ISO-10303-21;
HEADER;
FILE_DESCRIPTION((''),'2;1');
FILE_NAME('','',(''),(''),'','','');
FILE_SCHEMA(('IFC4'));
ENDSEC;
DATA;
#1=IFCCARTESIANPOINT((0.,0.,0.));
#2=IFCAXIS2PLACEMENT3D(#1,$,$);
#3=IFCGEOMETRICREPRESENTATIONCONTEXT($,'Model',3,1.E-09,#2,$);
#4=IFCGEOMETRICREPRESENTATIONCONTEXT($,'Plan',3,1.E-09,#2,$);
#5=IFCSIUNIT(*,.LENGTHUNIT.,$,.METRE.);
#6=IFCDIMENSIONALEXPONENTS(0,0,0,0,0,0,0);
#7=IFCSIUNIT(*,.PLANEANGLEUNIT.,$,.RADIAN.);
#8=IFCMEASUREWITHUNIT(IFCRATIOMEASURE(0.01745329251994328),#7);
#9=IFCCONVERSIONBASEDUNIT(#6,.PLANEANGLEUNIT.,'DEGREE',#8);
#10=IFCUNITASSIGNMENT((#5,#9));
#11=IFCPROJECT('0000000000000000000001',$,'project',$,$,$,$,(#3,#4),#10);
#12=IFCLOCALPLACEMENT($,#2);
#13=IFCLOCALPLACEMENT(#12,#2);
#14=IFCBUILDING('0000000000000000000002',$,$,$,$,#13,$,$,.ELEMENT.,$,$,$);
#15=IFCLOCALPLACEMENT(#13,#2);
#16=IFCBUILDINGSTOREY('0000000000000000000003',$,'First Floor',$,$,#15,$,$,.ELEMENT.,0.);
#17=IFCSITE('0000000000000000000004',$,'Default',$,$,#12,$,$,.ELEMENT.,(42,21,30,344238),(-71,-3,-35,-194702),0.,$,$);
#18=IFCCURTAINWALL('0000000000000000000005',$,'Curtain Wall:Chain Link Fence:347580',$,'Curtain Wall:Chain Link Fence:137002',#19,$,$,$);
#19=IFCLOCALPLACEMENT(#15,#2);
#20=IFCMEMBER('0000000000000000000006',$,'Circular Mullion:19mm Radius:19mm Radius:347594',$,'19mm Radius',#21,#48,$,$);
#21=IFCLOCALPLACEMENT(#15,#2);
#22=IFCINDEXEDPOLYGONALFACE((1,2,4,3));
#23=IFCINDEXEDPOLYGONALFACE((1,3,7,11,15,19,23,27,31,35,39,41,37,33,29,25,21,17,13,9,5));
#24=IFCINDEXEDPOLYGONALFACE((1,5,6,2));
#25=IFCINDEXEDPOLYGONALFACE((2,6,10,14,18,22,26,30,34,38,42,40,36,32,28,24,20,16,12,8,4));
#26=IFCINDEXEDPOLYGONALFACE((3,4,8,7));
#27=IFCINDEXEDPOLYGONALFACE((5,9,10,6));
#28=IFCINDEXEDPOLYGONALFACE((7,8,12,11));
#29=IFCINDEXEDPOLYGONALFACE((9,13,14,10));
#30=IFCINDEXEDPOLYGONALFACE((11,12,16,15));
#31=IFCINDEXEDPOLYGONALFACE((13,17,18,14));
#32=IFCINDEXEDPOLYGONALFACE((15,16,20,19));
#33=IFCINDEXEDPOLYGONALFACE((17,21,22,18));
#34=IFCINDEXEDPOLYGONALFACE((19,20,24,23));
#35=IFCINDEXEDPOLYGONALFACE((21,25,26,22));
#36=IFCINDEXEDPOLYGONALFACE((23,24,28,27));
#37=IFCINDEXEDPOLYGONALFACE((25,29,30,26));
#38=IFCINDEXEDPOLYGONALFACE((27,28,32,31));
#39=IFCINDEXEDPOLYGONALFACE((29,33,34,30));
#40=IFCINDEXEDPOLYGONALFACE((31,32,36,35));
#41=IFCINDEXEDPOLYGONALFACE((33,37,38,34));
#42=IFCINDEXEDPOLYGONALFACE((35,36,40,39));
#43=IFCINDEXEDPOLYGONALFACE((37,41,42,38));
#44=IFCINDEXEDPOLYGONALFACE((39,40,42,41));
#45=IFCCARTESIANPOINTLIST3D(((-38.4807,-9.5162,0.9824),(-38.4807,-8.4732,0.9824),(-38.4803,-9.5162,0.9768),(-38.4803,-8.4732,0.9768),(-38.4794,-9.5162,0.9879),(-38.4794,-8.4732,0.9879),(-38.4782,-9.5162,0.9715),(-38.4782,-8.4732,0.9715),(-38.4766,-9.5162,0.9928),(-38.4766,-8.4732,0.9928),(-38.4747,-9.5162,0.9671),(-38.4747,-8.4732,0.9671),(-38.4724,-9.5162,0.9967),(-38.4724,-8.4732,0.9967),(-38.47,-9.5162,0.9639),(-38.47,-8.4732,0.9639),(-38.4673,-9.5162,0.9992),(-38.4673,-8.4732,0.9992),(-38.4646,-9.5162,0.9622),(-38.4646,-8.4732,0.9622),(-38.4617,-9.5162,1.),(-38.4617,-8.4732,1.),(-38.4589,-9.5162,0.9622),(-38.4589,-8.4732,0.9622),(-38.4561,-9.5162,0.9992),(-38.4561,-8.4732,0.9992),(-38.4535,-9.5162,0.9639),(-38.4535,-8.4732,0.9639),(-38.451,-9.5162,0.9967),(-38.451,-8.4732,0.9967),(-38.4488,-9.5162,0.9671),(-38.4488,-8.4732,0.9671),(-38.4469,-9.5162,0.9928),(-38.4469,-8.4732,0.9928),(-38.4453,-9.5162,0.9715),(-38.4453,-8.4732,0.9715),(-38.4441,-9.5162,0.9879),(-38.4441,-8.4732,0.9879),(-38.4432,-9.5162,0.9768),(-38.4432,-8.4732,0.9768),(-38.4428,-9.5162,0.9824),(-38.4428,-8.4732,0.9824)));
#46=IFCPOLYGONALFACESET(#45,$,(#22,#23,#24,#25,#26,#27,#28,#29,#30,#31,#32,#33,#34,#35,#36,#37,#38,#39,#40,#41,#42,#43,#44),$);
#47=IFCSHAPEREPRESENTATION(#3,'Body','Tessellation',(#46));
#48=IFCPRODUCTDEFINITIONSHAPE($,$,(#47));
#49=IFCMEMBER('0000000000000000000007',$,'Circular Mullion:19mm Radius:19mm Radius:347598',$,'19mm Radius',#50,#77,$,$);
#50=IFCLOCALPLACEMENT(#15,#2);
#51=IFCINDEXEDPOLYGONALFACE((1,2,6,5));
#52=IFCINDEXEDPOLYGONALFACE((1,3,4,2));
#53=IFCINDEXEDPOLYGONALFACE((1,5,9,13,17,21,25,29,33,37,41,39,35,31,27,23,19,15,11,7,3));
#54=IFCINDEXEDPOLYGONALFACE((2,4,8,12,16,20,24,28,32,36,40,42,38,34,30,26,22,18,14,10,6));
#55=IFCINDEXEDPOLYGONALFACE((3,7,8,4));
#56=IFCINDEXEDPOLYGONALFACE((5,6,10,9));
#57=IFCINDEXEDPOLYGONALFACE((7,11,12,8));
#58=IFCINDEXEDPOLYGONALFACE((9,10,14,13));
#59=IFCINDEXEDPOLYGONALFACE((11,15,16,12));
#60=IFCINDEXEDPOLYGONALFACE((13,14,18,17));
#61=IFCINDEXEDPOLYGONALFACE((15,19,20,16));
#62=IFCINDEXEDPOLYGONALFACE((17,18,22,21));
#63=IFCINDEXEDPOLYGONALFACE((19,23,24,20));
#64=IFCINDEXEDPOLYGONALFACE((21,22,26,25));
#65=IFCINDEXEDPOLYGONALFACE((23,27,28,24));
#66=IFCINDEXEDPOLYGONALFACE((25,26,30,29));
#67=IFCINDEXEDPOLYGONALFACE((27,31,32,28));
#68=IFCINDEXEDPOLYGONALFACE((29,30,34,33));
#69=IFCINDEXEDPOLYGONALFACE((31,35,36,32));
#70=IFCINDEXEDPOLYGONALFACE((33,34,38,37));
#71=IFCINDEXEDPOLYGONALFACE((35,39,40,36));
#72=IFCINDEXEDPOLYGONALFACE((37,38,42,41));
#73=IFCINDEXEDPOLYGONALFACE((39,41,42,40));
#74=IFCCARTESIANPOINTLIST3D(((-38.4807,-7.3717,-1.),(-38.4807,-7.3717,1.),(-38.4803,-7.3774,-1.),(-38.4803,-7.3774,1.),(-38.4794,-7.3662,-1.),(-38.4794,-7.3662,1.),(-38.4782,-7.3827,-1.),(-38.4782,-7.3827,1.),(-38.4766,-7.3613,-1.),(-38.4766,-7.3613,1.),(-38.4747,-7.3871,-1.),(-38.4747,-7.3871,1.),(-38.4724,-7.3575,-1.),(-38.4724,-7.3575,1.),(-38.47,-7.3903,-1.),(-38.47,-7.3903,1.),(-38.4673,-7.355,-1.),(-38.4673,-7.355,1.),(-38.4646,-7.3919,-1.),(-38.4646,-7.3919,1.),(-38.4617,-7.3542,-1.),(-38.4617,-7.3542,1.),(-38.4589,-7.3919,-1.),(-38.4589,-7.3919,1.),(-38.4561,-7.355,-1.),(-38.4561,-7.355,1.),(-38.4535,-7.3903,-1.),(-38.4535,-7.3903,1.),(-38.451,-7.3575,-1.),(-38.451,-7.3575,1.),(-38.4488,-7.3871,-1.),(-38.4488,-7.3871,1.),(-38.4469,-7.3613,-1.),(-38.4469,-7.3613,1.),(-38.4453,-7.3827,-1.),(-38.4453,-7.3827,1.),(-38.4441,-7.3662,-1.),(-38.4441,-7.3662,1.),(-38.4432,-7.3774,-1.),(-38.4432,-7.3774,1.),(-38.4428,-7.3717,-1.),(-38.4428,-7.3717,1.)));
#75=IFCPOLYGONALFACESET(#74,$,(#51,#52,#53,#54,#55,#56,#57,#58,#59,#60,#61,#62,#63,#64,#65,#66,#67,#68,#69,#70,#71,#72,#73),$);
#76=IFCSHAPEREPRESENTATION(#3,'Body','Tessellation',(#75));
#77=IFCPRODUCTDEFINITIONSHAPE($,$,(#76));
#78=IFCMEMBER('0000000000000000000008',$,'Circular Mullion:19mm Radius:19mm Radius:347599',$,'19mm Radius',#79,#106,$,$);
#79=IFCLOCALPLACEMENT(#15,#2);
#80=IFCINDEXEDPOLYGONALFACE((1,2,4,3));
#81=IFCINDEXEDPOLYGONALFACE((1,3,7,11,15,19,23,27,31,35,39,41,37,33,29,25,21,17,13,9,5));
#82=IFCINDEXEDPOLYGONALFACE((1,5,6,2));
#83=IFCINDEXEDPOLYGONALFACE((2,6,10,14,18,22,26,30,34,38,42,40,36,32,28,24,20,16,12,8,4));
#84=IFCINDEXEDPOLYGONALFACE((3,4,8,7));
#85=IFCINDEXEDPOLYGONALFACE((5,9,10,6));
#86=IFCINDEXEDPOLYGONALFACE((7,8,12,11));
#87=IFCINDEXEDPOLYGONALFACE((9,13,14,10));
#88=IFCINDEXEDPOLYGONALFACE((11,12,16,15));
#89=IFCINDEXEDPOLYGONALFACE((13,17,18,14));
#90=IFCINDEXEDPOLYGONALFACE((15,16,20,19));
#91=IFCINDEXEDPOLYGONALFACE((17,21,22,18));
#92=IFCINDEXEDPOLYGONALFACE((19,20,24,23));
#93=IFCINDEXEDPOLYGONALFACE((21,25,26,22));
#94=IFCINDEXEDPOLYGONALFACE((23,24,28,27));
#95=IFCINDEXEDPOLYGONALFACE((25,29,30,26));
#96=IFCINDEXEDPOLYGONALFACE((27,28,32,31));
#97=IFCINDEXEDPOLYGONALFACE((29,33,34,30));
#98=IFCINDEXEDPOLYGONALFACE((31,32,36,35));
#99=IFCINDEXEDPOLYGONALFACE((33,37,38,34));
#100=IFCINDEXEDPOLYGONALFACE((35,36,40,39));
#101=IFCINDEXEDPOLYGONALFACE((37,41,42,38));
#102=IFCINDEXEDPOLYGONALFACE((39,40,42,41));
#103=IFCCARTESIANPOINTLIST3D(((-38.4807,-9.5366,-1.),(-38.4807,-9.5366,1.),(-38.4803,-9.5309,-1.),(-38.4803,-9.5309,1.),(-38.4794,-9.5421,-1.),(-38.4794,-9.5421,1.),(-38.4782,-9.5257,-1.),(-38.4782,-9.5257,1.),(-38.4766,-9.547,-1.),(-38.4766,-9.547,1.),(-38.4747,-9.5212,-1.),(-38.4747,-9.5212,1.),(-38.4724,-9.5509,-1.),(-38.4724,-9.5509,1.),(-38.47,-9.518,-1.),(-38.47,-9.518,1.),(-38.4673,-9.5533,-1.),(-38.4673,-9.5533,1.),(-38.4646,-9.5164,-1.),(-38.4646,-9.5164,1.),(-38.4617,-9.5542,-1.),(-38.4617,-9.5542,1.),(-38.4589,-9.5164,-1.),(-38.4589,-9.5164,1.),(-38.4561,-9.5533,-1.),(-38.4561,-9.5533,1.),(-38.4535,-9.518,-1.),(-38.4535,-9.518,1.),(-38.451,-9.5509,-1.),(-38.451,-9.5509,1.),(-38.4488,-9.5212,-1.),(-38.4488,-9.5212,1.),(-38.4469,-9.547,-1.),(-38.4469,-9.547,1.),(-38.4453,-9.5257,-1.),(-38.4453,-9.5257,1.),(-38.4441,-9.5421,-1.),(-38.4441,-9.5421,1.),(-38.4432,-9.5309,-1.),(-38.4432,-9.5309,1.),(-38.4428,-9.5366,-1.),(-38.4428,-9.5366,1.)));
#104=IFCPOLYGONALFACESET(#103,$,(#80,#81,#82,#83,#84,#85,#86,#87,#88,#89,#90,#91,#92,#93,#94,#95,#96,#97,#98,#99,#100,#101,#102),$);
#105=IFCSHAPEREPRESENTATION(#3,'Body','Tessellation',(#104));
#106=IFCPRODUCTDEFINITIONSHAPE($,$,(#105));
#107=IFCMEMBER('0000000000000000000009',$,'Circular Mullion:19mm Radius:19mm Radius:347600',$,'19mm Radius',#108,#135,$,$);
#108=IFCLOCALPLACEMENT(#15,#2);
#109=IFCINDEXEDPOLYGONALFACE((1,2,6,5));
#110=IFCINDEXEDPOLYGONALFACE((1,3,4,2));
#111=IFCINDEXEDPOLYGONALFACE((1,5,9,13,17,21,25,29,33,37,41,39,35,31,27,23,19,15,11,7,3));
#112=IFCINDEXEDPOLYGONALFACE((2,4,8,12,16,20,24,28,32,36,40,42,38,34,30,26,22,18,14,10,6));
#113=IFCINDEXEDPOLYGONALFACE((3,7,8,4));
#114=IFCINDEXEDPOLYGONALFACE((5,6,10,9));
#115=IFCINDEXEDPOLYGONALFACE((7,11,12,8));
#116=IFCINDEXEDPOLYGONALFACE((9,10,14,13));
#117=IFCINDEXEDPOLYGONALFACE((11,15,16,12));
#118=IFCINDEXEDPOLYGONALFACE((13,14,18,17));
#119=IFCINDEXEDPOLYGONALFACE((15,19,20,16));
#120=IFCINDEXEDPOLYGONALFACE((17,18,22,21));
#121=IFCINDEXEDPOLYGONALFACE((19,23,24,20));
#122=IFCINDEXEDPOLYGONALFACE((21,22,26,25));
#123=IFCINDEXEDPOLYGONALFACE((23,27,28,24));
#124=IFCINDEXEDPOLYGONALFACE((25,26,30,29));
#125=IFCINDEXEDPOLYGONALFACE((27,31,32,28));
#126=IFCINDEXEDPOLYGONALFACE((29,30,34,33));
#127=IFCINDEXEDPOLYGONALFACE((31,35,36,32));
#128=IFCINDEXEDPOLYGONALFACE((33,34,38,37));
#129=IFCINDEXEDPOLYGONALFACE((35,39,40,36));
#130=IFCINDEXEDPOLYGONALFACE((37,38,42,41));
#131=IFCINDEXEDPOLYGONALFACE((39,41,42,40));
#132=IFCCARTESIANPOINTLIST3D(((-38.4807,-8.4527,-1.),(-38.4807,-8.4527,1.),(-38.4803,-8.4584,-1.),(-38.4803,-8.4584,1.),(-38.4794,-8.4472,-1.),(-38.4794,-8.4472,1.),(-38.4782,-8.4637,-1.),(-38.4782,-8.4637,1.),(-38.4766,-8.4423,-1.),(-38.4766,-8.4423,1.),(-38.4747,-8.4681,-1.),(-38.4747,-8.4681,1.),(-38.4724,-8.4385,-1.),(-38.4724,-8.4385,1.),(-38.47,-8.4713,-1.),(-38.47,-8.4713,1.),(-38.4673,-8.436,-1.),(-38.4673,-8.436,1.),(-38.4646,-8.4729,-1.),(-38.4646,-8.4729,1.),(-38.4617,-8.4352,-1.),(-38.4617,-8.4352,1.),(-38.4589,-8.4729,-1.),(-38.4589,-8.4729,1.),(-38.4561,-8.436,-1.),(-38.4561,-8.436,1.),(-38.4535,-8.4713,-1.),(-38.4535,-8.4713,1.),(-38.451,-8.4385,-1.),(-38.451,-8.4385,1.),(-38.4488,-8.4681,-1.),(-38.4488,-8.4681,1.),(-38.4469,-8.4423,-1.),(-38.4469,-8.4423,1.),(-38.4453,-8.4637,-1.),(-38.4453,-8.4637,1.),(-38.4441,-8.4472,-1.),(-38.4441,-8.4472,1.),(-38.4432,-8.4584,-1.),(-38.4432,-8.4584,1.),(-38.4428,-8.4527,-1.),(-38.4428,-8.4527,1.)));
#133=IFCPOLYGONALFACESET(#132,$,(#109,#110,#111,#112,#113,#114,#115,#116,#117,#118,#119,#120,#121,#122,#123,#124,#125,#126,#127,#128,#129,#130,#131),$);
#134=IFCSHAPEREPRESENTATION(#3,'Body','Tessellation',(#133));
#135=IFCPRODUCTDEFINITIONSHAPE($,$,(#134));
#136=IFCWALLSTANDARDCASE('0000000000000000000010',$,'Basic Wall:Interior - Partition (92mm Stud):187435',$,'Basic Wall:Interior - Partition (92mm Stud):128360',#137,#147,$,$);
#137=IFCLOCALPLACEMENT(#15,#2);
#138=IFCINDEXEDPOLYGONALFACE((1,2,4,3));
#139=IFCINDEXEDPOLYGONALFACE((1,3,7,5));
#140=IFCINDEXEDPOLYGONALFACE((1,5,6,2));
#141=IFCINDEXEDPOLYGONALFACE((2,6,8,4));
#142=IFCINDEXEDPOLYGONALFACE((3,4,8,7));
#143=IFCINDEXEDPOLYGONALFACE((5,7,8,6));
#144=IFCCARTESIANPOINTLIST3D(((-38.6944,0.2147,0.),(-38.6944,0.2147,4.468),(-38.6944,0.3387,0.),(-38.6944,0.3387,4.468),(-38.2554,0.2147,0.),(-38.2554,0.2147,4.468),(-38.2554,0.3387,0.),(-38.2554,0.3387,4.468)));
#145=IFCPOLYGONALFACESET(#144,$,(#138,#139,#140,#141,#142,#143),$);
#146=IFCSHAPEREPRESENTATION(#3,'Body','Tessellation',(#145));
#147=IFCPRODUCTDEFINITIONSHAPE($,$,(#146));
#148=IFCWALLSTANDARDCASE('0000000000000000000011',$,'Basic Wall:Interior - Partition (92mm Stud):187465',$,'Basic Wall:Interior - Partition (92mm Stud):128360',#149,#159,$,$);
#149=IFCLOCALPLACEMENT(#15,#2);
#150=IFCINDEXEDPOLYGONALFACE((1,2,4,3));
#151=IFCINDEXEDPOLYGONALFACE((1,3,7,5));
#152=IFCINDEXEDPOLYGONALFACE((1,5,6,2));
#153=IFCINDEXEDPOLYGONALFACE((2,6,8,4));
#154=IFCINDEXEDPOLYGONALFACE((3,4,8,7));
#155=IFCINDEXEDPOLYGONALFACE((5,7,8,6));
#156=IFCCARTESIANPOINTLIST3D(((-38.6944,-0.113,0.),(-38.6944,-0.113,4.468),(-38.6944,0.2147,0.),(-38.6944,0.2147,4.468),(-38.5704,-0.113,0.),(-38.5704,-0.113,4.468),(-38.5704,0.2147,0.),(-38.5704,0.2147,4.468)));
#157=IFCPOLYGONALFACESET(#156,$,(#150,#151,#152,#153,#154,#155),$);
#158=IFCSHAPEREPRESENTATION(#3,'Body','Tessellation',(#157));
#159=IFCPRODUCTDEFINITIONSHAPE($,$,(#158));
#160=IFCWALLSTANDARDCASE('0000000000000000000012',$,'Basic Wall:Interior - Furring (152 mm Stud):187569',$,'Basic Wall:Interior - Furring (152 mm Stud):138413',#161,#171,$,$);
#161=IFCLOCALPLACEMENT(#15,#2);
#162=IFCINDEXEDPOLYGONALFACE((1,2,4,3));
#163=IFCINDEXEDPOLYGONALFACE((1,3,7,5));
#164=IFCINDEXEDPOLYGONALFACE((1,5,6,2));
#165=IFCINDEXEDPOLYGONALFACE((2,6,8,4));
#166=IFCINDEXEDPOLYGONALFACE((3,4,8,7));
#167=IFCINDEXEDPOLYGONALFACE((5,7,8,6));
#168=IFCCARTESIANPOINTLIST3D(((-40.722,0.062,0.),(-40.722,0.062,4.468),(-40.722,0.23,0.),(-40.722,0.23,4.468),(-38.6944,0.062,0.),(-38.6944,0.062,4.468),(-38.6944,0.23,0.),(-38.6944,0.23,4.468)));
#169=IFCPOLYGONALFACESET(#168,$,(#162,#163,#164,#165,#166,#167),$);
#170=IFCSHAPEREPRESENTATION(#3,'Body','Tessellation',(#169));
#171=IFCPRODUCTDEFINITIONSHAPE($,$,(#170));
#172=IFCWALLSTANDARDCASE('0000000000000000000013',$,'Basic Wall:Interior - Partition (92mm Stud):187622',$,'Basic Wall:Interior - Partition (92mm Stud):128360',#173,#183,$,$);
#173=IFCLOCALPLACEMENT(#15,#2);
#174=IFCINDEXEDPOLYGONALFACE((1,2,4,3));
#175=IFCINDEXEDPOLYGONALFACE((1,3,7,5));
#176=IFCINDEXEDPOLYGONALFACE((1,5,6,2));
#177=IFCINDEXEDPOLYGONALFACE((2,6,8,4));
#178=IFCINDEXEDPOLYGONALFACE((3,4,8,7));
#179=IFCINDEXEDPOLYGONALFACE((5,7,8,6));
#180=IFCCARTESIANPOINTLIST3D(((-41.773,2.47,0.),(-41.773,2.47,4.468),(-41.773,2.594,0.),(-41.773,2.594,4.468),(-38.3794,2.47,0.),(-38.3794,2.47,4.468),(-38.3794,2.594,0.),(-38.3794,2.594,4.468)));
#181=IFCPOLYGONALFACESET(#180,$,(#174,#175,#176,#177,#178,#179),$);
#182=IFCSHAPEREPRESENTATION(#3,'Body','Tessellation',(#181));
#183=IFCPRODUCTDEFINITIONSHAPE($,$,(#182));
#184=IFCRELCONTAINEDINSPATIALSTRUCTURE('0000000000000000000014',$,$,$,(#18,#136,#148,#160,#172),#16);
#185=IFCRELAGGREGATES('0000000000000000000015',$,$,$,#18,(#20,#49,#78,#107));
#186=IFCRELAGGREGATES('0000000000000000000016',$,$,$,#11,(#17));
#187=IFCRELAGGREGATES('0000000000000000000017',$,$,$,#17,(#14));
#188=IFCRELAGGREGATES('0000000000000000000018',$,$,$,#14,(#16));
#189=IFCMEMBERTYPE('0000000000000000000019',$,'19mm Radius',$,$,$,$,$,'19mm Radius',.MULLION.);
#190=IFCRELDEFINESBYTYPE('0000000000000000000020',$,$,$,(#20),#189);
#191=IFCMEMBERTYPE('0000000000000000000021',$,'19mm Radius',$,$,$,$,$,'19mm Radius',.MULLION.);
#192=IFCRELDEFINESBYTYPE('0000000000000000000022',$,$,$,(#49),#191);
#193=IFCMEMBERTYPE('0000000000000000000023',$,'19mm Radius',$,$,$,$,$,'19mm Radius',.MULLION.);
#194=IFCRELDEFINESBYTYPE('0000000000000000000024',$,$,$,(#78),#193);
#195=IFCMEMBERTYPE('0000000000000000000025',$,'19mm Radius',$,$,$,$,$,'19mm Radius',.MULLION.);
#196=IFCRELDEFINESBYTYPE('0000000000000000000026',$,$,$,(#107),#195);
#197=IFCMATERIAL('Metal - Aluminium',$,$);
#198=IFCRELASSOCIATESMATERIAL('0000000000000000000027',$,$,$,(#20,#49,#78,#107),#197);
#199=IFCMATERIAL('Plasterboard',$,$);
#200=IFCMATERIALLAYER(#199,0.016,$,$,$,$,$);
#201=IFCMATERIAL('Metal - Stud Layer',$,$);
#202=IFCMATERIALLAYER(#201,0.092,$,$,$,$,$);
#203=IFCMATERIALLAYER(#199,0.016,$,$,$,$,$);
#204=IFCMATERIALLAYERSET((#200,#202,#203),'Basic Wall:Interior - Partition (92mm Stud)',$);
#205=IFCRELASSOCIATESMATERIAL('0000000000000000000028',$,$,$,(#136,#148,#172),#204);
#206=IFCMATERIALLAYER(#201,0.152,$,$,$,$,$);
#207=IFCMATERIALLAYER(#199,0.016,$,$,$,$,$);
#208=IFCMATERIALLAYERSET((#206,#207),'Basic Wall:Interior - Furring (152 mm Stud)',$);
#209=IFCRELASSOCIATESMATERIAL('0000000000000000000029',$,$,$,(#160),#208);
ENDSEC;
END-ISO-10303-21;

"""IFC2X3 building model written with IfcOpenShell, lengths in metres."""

from ifc_helpers import new_model, entity, si_unit, converted_unit, frame, frame_2d, origin, origin_2d_with_axis, place, context, project, spatial, rectangle, circle, extrude, source, transform, mapped, material, layer, layer_set, layer_usage, type_object, type_shapes, element, aggregate, save


model = new_model("IFC2X3")

# Units and contexts
model_context = context("Model", 3, precision=1e-09, world=origin())
plan_context = context("Plan", 3, precision=1e-09, world=origin())
ifc_project = project(units=[si_unit("LENGTHUNIT", "METRE"), converted_unit("PLANEANGLEUNIT", "DEGREE", entity("IfcRatioMeasure", 0.01745329251994328), si_unit("PLANEANGLEUNIT", "RADIAN"), dimensions=[0, 0, 0, 0, 0, 0, 0])], contexts=[model_context, plan_context])

# Site, building, storey
site_placement = place(None, origin())
site = spatial("IfcSite", under=ifc_project, at=site_placement, Name="Default", CompositionType="ELEMENT", RefLatitude=(42, 21, 30, 344238), RefLongitude=(-71, -3, -35, -194702), RefElevation=0.0)
building_placement = place(site_placement, origin())
building = spatial("IfcBuilding", under=site, at=building_placement, CompositionType="ELEMENT")
storey_placement = place(building_placement, origin())
storey = spatial("IfcBuildingStorey", under=building, at=storey_placement, Name="First Floor", CompositionType="ELEMENT", Elevation=0.0)

# Curtain wall, members
ifc_material_1 = material(Name="Metal - Aluminium")
placement = place(building_placement, frame((0.0, 0.0, -1.0)))
curtain_wall_1_placement = place(storey_placement, origin())
curtain_wall_1 = element("IfcCurtainWall", 1, at=curtain_wall_1_placement, inside=storey, Name="Curtain Wall:Chain Link Fence:347580", ObjectType="Curtain Wall:Chain Link Fence:137002")
member_type_1 = type_object("IfcMemberType", Name="19mm Radius", ElementType="19mm Radius", PredefinedType="MULLION")
shared_shape_1 = source(origin(), model_context, "Body", "SweptSolid", [
    extrude(circle(Radius=0.019, at=origin_2d_with_axis()), frame((-0.019, 0.0, -1.043)), (0.0, 0.0, 1.0), 1.043),
])
type_shapes(member_type_1, [shared_shape_1])
member_1_placement = place(storey_placement, frame((-38.4617, -8.4732, 1.0), z_axis=(0.0, 1.0, 0.0), x_axis=(0.0, 0.0, 1.0)))
member_1 = element("IfcMember", 2, at=member_1_placement, type_object=member_type_1, material=ifc_material_1, Name="Circular Mullion:19mm Radius:19mm Radius:347594", ObjectType="19mm Radius", context=model_context, shape_type="MappedRepresentation", body=[
    mapped(shared_shape_1, transform((0.0, 0.0, 0.0), scale=1.0)),
])
member_type_2 = type_object("IfcMemberType", Name="19mm Radius", ElementType="19mm Radius", PredefinedType="MULLION")
shared_shape_2 = source(origin(), model_context, "Body", "SweptSolid", [
    extrude(circle(Radius=0.019, at=origin_2d_with_axis()), frame((-0.019, 0.0, -2.0)), (0.0, 0.0, 1.0), 2.0),
])
type_shapes(member_type_2, [shared_shape_2])
member_2_placement = place(placement, frame((-38.4617, -7.3542, 0.0), z_axis=(0.0, 0.0, -1.0), x_axis=(0.0, 1.0, 0.0)))
member_2 = element("IfcMember", 3, at=member_2_placement, type_object=member_type_2, material=ifc_material_1, Name="Circular Mullion:19mm Radius:19mm Radius:347598", ObjectType="19mm Radius", context=model_context, shape_type="MappedRepresentation", body=[
    mapped(shared_shape_2, transform((0.0, 0.0, 0.0), scale=1.0)),
])
member_type_3 = type_object("IfcMemberType", Name="19mm Radius", ElementType="19mm Radius", PredefinedType="MULLION")
shared_shape_3 = source(origin(), model_context, "Body", "SweptSolid", [
    extrude(circle(Radius=0.019, at=origin_2d_with_axis()), frame((-0.019, 0.0, -2.0)), (0.0, 0.0, 1.0), 2.0),
])
type_shapes(member_type_3, [shared_shape_3])
member_3_placement = place(placement, frame((-38.4617, -9.5542, 2.0), z_axis=(0.0, 0.0, 1.0), x_axis=(0.0, -1.0, 0.0)))
member_3 = element("IfcMember", 4, at=member_3_placement, type_object=member_type_3, material=ifc_material_1, Name="Circular Mullion:19mm Radius:19mm Radius:347599", ObjectType="19mm Radius", context=model_context, shape_type="MappedRepresentation", body=[
    mapped(shared_shape_3, transform((0.0, 0.0, 0.0), scale=1.0)),
])
member_type_4 = type_object("IfcMemberType", Name="19mm Radius", ElementType="19mm Radius", PredefinedType="MULLION")
shared_shape_4 = source(origin(), model_context, "Body", "SweptSolid", [
    extrude(circle(Radius=0.019, at=origin_2d_with_axis()), frame((0.0, 0.0, -2.0)), (0.0, 0.0, 1.0), 2.0),
])
type_shapes(member_type_4, [shared_shape_4])
member_4_placement = place(placement, frame((-38.4617, -8.4542, 0.0), z_axis=(0.0, 0.0, -1.0), x_axis=(0.0, 1.0, 0.0)))
member_4 = element("IfcMember", 5, at=member_4_placement, type_object=member_type_4, material=ifc_material_1, Name="Circular Mullion:19mm Radius:19mm Radius:347600", ObjectType="19mm Radius", context=model_context, shape_type="MappedRepresentation", body=[
    mapped(shared_shape_4, transform((0.0, 0.0, 0.0), scale=1.0)),
])

aggregate(curtain_wall_1, [member_1, member_2, member_3, member_4])

# Walls
ifc_material_2 = material(Name="Plasterboard")
ifc_layer_1 = layer(ifc_material_2, 0.016)
ifc_material_3 = material(Name="Metal - Stud Layer")
ifc_layer_2 = layer(ifc_material_3, 0.092)
ifc_layer_3 = layer(ifc_material_2, 0.016)
ifc_layer_set_1 = layer_set([ifc_layer_1, ifc_layer_2, ifc_layer_3], Name="Basic Wall:Interior - Partition (92mm Stud)")
ifc_layer_usage_1 = layer_usage(ifc_layer_set_1, "AXIS2", "NEGATIVE", 0.062)
wall_1_placement = place(storey_placement, frame((-38.2554, 0.2767, 0.0), z_axis=(0.0, 0.0, 1.0), x_axis=(-1.0, 0.0, 0.0)))
element("IfcWallStandardCase", 6, at=wall_1_placement, inside=storey, material=ifc_layer_usage_1, Name="Basic Wall:Interior - Partition (92mm Stud):187435", ObjectType="Basic Wall:Interior - Partition (92mm Stud):128360", context=model_context, shape_type="SweptSolid", body=[
    extrude(rectangle(XDim=0.439, YDim=0.124, at=frame_2d((0.2195, 0.0), x_axis=(-1.0, 0.0))), origin(), (0.0, 0.0, 1.0), 4.468),
])
ifc_layer_usage_2 = layer_usage(ifc_layer_set_1, "AXIS2", "NEGATIVE", 0.062)
wall_2_placement = place(storey_placement, frame((-38.6324, 0.2147, 0.0), z_axis=(0.0, 0.0, 1.0), x_axis=(0.0, -1.0, 0.0)))
element("IfcWallStandardCase", 7, at=wall_2_placement, inside=storey, material=ifc_layer_usage_2, Name="Basic Wall:Interior - Partition (92mm Stud):187465", ObjectType="Basic Wall:Interior - Partition (92mm Stud):128360", context=model_context, shape_type="SweptSolid", body=[
    extrude(rectangle(XDim=0.3277, YDim=0.124, at=frame_2d((0.1639, 0.0), x_axis=(-1.0, 0.0))), origin(), (0.0, 0.0, 1.0), 4.468),
])
ifc_layer_4 = layer(ifc_material_3, 0.152)
ifc_layer_5 = layer(ifc_material_2, 0.016)
ifc_layer_set_2 = layer_set([ifc_layer_4, ifc_layer_5], Name="Basic Wall:Interior - Furring (152 mm Stud)")
ifc_layer_usage_3 = layer_usage(ifc_layer_set_2, "AXIS2", "POSITIVE", -0.084)
wall_3_placement = place(storey_placement, frame((-40.722, 0.146, 0.0)))
element("IfcWallStandardCase", 8, at=wall_3_placement, inside=storey, material=ifc_layer_usage_3, Name="Basic Wall:Interior - Furring (152 mm Stud):187569", ObjectType="Basic Wall:Interior - Furring (152 mm Stud):138413", context=model_context, shape_type="SweptSolid", body=[
    extrude(rectangle(XDim=2.0276, YDim=0.168, at=frame_2d((1.0138, 0.0), x_axis=(-1.0, 0.0))), origin(), (0.0, 0.0, 1.0), 4.468),
])
ifc_layer_usage_4 = layer_usage(ifc_layer_set_1, "AXIS2", "NEGATIVE", 0.062)
wall_4_placement = place(storey_placement, frame((-38.3794, 2.532, 0.0), z_axis=(0.0, 0.0, 1.0), x_axis=(-1.0, 0.0, 0.0)))
element("IfcWallStandardCase", 9, at=wall_4_placement, inside=storey, material=ifc_layer_usage_4, Name="Basic Wall:Interior - Partition (92mm Stud):187622", ObjectType="Basic Wall:Interior - Partition (92mm Stud):128360", context=model_context, shape_type="SweptSolid", body=[
    extrude(rectangle(XDim=3.3936, YDim=0.124, at=frame_2d((1.6968, 0.0), x_axis=(-1.0, 0.0))), origin(), (0.0, 0.0, 1.0), 4.468),
])

save(model, "model.ifc")
